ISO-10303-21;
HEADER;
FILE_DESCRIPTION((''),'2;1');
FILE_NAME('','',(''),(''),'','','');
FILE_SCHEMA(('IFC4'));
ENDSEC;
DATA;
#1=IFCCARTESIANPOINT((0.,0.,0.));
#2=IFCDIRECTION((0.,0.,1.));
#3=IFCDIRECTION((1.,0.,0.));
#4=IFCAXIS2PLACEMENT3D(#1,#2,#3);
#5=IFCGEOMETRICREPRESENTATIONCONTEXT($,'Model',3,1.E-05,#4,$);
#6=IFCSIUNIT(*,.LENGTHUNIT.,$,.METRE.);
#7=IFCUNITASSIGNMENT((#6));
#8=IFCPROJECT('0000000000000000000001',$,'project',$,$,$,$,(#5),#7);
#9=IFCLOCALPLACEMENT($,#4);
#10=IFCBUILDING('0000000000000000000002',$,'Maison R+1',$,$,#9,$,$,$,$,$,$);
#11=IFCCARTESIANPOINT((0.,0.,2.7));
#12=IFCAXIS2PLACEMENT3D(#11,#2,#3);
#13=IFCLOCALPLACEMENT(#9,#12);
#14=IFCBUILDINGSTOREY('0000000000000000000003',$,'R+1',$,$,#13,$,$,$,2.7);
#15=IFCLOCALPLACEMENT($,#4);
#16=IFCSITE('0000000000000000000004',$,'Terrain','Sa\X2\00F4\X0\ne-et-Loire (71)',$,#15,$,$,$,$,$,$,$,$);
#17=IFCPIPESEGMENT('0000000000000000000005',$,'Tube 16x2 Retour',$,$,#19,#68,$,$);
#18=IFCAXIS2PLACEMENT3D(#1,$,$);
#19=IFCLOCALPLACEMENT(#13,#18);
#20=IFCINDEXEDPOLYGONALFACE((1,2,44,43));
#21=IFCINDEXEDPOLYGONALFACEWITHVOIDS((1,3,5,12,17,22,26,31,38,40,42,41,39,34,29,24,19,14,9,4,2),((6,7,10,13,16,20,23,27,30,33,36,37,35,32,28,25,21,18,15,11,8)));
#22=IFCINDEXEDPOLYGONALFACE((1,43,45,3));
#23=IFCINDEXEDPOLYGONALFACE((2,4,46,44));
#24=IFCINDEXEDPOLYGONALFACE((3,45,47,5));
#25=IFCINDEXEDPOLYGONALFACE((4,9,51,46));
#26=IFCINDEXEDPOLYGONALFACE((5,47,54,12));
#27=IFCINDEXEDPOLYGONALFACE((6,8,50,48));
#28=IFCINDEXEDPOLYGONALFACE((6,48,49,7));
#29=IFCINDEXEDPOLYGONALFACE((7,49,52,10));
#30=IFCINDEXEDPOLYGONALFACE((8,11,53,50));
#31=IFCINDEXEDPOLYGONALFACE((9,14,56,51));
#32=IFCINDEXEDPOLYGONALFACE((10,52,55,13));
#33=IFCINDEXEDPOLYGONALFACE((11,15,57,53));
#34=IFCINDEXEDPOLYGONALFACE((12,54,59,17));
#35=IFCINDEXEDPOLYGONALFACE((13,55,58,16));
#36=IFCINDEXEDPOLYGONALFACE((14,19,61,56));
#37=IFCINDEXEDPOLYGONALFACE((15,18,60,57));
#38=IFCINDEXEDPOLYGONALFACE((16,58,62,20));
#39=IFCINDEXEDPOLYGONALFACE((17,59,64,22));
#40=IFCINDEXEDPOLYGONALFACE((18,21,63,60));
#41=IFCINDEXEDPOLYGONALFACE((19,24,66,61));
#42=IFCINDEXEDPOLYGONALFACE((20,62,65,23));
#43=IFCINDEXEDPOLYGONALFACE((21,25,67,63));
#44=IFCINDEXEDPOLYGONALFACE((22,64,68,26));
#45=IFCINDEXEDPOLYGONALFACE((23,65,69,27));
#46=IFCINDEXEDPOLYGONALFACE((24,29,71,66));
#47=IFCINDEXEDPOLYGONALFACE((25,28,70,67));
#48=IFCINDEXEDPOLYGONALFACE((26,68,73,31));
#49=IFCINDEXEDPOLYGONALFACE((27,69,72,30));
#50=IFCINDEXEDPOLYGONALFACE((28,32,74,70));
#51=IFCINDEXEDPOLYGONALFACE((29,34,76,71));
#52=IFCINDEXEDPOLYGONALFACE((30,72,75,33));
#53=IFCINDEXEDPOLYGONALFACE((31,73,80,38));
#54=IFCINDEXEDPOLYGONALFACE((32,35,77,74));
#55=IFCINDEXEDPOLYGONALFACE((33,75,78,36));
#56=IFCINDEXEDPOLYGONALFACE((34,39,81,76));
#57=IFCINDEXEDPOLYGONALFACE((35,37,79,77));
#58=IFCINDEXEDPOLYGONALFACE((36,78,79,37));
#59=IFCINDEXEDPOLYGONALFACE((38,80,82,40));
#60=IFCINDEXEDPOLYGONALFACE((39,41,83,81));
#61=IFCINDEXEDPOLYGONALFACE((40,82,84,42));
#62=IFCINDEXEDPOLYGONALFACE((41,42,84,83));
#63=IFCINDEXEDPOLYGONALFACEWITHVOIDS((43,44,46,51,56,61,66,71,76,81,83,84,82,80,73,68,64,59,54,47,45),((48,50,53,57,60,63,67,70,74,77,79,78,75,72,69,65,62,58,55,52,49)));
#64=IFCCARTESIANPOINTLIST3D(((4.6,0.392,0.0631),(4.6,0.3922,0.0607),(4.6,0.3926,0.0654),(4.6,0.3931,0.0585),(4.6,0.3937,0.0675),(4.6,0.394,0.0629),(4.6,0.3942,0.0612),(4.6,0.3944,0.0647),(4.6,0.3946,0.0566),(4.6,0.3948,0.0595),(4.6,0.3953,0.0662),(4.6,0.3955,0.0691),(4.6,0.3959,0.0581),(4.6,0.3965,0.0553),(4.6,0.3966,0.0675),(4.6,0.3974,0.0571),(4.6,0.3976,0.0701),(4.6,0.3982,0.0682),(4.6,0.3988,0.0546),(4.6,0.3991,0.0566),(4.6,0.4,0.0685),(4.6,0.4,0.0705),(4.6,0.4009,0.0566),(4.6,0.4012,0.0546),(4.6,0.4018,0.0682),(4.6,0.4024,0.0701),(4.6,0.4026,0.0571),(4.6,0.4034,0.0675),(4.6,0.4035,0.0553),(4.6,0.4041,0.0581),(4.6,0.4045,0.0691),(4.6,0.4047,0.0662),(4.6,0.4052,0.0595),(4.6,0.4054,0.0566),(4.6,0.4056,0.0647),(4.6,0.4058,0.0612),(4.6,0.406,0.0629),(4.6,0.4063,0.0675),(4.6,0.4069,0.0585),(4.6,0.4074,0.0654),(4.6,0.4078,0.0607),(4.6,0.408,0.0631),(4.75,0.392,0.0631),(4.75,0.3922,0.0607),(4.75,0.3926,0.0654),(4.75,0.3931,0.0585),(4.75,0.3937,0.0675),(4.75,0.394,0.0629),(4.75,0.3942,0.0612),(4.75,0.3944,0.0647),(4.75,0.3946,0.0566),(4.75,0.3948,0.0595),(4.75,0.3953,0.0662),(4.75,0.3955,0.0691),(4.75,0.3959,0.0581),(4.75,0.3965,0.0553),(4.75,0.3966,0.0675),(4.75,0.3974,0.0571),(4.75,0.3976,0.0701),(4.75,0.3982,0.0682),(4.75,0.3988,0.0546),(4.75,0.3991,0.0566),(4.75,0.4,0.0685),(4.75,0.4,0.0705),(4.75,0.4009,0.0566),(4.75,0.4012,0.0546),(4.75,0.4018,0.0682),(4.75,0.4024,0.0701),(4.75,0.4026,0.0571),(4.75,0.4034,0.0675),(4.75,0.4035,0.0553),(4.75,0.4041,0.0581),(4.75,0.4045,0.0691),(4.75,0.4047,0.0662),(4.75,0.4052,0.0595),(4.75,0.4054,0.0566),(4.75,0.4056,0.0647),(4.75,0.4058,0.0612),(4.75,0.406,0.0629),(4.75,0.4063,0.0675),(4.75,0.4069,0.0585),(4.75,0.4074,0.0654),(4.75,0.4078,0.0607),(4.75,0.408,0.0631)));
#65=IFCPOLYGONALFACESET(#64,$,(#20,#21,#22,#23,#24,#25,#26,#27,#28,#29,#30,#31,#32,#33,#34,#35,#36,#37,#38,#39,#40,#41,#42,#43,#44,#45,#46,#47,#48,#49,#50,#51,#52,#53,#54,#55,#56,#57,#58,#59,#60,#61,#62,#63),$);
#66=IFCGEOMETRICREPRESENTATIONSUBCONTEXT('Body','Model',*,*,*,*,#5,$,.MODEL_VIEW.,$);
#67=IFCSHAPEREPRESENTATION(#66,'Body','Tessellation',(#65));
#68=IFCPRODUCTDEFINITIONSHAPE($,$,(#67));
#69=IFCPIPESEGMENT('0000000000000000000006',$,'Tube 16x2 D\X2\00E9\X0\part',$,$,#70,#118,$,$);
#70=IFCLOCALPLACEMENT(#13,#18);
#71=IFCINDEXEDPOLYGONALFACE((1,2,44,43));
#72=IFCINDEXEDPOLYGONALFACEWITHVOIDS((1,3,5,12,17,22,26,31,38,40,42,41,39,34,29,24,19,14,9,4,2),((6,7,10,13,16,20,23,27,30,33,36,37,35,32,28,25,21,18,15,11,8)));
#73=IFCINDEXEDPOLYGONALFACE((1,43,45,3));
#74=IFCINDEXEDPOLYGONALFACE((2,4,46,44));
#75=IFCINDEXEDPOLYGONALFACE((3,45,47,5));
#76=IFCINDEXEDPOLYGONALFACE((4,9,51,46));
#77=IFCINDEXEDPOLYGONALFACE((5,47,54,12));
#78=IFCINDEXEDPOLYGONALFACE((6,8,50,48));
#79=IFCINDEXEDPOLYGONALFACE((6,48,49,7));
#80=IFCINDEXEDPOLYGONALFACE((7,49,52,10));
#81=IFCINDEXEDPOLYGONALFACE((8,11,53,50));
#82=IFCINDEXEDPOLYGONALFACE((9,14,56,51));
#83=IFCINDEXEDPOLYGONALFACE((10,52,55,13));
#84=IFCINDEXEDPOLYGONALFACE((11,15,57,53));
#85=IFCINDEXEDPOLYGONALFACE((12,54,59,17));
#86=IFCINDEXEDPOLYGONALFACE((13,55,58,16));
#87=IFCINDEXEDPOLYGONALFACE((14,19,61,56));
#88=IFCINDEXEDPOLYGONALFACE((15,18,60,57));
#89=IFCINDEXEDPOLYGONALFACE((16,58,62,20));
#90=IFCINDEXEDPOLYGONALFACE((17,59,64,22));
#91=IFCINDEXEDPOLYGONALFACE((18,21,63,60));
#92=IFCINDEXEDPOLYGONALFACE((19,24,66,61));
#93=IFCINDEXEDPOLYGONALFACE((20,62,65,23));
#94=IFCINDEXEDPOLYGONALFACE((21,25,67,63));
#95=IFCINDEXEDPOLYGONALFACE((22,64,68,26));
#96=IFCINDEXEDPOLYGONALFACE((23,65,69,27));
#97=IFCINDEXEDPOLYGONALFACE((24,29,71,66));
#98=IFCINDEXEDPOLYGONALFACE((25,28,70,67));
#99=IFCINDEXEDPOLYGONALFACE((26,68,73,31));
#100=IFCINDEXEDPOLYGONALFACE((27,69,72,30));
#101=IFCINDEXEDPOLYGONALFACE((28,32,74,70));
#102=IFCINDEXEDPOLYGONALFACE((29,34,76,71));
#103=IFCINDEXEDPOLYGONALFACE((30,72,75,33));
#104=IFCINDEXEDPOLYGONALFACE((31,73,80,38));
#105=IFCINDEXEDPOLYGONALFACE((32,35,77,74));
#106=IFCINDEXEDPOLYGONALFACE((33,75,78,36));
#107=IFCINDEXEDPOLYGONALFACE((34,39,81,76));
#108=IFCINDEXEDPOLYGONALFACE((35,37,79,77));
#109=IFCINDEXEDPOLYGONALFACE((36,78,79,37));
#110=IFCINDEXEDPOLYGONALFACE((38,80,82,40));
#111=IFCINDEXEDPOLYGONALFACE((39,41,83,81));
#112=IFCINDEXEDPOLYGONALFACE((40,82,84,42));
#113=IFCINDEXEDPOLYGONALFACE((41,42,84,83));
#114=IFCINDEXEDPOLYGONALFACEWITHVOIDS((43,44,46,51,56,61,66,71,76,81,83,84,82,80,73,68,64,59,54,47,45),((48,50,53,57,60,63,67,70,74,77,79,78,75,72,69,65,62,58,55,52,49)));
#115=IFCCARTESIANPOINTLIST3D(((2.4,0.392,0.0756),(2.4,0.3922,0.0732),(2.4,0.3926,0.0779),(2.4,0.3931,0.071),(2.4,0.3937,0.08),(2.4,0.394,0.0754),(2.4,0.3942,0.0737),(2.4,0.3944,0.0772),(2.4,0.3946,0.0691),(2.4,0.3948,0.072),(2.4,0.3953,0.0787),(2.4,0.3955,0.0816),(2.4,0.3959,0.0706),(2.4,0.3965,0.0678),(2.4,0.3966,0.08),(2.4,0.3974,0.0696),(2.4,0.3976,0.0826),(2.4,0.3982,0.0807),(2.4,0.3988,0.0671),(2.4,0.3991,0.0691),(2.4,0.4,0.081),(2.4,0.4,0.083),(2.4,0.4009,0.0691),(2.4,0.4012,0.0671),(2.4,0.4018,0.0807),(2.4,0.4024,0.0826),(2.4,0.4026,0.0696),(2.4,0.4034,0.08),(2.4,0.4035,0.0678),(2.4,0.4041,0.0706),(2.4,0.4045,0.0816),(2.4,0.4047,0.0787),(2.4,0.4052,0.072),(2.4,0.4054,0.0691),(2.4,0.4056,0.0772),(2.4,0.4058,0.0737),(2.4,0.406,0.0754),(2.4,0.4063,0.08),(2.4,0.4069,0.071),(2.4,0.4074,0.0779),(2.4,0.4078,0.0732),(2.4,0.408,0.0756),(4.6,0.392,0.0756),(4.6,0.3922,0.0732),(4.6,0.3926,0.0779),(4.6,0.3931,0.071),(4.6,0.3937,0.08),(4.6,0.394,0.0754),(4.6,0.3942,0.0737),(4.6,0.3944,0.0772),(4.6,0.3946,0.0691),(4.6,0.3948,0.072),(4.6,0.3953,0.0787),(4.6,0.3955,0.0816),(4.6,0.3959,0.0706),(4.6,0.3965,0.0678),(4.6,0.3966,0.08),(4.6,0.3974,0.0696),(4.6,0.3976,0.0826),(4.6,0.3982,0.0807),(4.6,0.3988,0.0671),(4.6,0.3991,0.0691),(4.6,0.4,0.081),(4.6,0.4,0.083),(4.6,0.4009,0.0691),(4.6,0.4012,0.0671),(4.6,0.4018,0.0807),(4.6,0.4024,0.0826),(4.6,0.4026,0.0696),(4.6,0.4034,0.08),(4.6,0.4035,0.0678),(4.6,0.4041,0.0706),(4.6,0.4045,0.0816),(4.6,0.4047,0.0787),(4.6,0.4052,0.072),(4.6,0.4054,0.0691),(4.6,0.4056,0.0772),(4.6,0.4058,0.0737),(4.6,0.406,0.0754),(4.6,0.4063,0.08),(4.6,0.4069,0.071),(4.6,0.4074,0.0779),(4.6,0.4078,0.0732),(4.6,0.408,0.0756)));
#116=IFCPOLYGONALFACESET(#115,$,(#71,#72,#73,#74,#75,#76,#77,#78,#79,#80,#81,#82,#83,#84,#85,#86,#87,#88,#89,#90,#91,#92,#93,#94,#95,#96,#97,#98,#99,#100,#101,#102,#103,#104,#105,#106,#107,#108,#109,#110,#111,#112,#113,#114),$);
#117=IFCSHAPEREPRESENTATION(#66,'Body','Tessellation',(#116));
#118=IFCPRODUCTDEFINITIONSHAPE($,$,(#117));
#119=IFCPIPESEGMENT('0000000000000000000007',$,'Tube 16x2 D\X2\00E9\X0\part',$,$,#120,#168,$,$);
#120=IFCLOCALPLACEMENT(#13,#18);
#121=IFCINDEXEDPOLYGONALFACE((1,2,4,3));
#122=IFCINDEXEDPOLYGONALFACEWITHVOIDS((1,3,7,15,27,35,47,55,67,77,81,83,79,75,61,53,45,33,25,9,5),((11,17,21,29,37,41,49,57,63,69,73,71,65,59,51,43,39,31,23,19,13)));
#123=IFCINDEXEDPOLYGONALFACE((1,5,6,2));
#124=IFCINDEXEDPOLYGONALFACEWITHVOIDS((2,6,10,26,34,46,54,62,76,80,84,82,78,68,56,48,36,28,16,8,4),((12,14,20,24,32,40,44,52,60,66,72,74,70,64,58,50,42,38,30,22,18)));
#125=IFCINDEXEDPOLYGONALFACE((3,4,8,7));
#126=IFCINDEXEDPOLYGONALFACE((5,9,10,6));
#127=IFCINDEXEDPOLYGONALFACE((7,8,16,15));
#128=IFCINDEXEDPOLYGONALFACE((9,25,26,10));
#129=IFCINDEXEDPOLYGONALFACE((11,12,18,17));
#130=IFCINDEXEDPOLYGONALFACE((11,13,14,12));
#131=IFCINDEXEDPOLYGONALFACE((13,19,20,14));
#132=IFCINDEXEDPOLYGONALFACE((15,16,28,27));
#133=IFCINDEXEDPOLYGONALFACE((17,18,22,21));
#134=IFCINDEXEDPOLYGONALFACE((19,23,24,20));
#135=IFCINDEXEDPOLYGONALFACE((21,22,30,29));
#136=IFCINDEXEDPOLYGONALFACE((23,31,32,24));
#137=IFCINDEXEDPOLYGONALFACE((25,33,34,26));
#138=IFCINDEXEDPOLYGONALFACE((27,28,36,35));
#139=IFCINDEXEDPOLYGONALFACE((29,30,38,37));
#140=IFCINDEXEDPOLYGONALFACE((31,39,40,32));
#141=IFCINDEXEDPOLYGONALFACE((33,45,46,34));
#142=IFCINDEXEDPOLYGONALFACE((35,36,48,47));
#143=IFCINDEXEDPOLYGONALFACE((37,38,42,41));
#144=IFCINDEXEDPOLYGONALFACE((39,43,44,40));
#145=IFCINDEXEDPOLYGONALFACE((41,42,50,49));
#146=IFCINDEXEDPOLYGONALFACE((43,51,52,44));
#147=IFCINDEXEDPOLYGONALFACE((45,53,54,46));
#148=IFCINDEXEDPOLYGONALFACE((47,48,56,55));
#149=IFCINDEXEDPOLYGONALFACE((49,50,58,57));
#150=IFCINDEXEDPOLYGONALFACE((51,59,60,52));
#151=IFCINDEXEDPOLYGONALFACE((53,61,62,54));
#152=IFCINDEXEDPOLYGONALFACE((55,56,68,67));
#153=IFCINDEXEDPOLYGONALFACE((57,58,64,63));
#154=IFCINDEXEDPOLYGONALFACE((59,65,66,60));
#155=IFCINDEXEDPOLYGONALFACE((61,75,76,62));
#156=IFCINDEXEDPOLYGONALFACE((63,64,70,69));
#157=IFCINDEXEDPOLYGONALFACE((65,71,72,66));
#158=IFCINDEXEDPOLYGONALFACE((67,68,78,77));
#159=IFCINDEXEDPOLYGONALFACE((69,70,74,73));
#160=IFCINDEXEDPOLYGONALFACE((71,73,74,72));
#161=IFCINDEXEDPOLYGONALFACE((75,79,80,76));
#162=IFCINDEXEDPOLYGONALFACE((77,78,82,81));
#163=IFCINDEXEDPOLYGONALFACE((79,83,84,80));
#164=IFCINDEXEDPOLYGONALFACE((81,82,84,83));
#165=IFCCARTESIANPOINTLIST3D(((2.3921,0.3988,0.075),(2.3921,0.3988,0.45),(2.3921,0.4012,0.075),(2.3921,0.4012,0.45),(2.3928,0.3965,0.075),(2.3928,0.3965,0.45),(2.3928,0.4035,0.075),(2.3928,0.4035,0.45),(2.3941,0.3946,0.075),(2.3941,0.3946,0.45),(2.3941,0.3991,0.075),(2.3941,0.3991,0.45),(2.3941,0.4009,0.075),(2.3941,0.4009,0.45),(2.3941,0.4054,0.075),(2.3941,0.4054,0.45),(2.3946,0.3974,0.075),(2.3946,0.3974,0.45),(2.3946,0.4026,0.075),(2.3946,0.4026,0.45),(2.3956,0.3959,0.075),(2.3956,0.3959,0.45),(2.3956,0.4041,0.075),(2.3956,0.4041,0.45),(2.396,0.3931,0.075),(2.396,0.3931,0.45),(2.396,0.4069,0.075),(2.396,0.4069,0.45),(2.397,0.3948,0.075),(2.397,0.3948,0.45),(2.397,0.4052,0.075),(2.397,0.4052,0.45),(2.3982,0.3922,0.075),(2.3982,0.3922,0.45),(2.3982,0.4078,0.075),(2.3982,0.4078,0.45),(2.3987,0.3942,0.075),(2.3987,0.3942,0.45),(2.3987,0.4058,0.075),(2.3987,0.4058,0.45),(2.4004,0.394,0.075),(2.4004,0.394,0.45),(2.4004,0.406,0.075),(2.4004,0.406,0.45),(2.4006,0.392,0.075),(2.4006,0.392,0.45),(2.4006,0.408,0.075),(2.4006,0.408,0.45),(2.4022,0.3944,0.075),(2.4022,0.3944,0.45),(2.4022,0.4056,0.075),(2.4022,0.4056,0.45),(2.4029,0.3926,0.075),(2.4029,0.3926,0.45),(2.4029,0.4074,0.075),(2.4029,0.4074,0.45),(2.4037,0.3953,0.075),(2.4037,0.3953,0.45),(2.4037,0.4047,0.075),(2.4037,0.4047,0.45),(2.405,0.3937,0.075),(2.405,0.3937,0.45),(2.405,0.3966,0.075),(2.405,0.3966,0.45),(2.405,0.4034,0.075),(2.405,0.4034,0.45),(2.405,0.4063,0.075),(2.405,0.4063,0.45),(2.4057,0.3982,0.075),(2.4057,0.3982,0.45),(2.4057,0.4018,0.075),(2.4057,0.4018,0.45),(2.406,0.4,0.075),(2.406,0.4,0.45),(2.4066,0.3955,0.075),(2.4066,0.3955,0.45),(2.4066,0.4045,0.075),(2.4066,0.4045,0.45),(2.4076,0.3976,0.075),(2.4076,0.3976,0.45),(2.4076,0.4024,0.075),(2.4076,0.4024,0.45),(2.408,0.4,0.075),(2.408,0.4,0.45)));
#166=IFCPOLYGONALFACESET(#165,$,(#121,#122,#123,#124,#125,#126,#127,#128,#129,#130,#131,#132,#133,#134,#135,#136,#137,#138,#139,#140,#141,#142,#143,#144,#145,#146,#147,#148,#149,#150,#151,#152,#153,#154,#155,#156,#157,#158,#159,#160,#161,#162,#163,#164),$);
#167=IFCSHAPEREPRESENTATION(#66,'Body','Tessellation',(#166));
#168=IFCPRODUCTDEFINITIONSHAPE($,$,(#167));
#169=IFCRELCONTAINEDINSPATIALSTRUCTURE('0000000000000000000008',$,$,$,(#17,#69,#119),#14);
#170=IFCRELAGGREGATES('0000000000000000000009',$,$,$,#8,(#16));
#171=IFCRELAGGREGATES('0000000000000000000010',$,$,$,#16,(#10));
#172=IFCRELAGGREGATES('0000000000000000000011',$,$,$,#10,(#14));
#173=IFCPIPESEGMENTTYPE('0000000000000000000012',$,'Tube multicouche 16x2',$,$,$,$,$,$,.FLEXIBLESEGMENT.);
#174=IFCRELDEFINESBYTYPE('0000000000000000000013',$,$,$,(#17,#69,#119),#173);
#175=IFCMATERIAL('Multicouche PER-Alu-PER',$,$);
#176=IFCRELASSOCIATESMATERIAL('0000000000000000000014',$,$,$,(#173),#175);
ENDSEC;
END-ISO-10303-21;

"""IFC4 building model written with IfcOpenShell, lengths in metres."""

from ifc_helpers import new_model, si_unit, frame, origin_with_axes, place, context, subcontext, project, spatial, hollow_circle, extrude, material, type_object, element, save


model = new_model("IFC4")

# Units and contexts
model_context = context("Model", 3, precision=1e-05, world=origin_with_axes())
body_context = subcontext(model_context, "Body", "Model", "MODEL_VIEW")
ifc_project = project(units=[si_unit("LENGTHUNIT", "METRE")], contexts=[model_context])

# Site, building, storey
site_placement = place(None, origin_with_axes())
site = spatial("IfcSite", under=ifc_project, at=site_placement, Name="Terrain", Description="Saône-et-Loire (71)")
building_placement = place(None, origin_with_axes())
building = spatial("IfcBuilding", under=site, at=building_placement, Name="Maison R+1")
storey_placement = place(building_placement, frame((0.0, 0.0, 2.7), z_axis=(0.0, 0.0, 1.0), x_axis=(1.0, 0.0, 0.0)))
storey = spatial("IfcBuildingStorey", under=building, at=storey_placement, Name="R+1", Elevation=2.7)

# Pipe segments
ifc_material_1 = material(Name="Multicouche PER-Alu-PER")
pipe_segment_type = type_object("IfcPipeSegmentType", Name="Tube multicouche 16x2", PredefinedType="FLEXIBLESEGMENT", material=ifc_material_1)
pipe_segment_1_placement = place(storey_placement, frame((4.6, 0.4, 0.0625), z_axis=(1.0, 0.0, 0.0), x_axis=(0.0, 0.0, 1.0)))
element("IfcPipeSegment", 1, at=pipe_segment_1_placement, inside=storey, type_object=pipe_segment_type, Name="Tube 16x2 Retour", context=body_context, shape_type="SweptSolid", body=[
    extrude(hollow_circle(Radius=0.008, WallThickness=0.002), origin_with_axes(), (0.0, 0.0, 1.0), 0.15),
])
pipe_segment_2_placement = place(storey_placement, frame((4.6, 0.4, 0.075), z_axis=(-1.0, 0.0, 0.0), x_axis=(0.0, 0.0, 1.0)))
element("IfcPipeSegment", 2, at=pipe_segment_2_placement, inside=storey, type_object=pipe_segment_type, Name="Tube 16x2 Départ", context=body_context, shape_type="SweptSolid", body=[
    extrude(hollow_circle(Radius=0.008, WallThickness=0.002), origin_with_axes(), (0.0, 0.0, 1.0), 2.2),
])
pipe_segment_3_placement = place(storey_placement, frame((2.4, 0.4, 0.075), z_axis=(0.0, 0.0, 1.0), x_axis=(1.0, 0.0, 0.0)))
element("IfcPipeSegment", 3, at=pipe_segment_3_placement, inside=storey, type_object=pipe_segment_type, Name="Tube 16x2 Départ", context=body_context, shape_type="SweptSolid", body=[
    extrude(hollow_circle(Radius=0.008, WallThickness=0.002), origin_with_axes(), (0.0, 0.0, 1.0), 0.375),
])

save(model, "model.ifc")
